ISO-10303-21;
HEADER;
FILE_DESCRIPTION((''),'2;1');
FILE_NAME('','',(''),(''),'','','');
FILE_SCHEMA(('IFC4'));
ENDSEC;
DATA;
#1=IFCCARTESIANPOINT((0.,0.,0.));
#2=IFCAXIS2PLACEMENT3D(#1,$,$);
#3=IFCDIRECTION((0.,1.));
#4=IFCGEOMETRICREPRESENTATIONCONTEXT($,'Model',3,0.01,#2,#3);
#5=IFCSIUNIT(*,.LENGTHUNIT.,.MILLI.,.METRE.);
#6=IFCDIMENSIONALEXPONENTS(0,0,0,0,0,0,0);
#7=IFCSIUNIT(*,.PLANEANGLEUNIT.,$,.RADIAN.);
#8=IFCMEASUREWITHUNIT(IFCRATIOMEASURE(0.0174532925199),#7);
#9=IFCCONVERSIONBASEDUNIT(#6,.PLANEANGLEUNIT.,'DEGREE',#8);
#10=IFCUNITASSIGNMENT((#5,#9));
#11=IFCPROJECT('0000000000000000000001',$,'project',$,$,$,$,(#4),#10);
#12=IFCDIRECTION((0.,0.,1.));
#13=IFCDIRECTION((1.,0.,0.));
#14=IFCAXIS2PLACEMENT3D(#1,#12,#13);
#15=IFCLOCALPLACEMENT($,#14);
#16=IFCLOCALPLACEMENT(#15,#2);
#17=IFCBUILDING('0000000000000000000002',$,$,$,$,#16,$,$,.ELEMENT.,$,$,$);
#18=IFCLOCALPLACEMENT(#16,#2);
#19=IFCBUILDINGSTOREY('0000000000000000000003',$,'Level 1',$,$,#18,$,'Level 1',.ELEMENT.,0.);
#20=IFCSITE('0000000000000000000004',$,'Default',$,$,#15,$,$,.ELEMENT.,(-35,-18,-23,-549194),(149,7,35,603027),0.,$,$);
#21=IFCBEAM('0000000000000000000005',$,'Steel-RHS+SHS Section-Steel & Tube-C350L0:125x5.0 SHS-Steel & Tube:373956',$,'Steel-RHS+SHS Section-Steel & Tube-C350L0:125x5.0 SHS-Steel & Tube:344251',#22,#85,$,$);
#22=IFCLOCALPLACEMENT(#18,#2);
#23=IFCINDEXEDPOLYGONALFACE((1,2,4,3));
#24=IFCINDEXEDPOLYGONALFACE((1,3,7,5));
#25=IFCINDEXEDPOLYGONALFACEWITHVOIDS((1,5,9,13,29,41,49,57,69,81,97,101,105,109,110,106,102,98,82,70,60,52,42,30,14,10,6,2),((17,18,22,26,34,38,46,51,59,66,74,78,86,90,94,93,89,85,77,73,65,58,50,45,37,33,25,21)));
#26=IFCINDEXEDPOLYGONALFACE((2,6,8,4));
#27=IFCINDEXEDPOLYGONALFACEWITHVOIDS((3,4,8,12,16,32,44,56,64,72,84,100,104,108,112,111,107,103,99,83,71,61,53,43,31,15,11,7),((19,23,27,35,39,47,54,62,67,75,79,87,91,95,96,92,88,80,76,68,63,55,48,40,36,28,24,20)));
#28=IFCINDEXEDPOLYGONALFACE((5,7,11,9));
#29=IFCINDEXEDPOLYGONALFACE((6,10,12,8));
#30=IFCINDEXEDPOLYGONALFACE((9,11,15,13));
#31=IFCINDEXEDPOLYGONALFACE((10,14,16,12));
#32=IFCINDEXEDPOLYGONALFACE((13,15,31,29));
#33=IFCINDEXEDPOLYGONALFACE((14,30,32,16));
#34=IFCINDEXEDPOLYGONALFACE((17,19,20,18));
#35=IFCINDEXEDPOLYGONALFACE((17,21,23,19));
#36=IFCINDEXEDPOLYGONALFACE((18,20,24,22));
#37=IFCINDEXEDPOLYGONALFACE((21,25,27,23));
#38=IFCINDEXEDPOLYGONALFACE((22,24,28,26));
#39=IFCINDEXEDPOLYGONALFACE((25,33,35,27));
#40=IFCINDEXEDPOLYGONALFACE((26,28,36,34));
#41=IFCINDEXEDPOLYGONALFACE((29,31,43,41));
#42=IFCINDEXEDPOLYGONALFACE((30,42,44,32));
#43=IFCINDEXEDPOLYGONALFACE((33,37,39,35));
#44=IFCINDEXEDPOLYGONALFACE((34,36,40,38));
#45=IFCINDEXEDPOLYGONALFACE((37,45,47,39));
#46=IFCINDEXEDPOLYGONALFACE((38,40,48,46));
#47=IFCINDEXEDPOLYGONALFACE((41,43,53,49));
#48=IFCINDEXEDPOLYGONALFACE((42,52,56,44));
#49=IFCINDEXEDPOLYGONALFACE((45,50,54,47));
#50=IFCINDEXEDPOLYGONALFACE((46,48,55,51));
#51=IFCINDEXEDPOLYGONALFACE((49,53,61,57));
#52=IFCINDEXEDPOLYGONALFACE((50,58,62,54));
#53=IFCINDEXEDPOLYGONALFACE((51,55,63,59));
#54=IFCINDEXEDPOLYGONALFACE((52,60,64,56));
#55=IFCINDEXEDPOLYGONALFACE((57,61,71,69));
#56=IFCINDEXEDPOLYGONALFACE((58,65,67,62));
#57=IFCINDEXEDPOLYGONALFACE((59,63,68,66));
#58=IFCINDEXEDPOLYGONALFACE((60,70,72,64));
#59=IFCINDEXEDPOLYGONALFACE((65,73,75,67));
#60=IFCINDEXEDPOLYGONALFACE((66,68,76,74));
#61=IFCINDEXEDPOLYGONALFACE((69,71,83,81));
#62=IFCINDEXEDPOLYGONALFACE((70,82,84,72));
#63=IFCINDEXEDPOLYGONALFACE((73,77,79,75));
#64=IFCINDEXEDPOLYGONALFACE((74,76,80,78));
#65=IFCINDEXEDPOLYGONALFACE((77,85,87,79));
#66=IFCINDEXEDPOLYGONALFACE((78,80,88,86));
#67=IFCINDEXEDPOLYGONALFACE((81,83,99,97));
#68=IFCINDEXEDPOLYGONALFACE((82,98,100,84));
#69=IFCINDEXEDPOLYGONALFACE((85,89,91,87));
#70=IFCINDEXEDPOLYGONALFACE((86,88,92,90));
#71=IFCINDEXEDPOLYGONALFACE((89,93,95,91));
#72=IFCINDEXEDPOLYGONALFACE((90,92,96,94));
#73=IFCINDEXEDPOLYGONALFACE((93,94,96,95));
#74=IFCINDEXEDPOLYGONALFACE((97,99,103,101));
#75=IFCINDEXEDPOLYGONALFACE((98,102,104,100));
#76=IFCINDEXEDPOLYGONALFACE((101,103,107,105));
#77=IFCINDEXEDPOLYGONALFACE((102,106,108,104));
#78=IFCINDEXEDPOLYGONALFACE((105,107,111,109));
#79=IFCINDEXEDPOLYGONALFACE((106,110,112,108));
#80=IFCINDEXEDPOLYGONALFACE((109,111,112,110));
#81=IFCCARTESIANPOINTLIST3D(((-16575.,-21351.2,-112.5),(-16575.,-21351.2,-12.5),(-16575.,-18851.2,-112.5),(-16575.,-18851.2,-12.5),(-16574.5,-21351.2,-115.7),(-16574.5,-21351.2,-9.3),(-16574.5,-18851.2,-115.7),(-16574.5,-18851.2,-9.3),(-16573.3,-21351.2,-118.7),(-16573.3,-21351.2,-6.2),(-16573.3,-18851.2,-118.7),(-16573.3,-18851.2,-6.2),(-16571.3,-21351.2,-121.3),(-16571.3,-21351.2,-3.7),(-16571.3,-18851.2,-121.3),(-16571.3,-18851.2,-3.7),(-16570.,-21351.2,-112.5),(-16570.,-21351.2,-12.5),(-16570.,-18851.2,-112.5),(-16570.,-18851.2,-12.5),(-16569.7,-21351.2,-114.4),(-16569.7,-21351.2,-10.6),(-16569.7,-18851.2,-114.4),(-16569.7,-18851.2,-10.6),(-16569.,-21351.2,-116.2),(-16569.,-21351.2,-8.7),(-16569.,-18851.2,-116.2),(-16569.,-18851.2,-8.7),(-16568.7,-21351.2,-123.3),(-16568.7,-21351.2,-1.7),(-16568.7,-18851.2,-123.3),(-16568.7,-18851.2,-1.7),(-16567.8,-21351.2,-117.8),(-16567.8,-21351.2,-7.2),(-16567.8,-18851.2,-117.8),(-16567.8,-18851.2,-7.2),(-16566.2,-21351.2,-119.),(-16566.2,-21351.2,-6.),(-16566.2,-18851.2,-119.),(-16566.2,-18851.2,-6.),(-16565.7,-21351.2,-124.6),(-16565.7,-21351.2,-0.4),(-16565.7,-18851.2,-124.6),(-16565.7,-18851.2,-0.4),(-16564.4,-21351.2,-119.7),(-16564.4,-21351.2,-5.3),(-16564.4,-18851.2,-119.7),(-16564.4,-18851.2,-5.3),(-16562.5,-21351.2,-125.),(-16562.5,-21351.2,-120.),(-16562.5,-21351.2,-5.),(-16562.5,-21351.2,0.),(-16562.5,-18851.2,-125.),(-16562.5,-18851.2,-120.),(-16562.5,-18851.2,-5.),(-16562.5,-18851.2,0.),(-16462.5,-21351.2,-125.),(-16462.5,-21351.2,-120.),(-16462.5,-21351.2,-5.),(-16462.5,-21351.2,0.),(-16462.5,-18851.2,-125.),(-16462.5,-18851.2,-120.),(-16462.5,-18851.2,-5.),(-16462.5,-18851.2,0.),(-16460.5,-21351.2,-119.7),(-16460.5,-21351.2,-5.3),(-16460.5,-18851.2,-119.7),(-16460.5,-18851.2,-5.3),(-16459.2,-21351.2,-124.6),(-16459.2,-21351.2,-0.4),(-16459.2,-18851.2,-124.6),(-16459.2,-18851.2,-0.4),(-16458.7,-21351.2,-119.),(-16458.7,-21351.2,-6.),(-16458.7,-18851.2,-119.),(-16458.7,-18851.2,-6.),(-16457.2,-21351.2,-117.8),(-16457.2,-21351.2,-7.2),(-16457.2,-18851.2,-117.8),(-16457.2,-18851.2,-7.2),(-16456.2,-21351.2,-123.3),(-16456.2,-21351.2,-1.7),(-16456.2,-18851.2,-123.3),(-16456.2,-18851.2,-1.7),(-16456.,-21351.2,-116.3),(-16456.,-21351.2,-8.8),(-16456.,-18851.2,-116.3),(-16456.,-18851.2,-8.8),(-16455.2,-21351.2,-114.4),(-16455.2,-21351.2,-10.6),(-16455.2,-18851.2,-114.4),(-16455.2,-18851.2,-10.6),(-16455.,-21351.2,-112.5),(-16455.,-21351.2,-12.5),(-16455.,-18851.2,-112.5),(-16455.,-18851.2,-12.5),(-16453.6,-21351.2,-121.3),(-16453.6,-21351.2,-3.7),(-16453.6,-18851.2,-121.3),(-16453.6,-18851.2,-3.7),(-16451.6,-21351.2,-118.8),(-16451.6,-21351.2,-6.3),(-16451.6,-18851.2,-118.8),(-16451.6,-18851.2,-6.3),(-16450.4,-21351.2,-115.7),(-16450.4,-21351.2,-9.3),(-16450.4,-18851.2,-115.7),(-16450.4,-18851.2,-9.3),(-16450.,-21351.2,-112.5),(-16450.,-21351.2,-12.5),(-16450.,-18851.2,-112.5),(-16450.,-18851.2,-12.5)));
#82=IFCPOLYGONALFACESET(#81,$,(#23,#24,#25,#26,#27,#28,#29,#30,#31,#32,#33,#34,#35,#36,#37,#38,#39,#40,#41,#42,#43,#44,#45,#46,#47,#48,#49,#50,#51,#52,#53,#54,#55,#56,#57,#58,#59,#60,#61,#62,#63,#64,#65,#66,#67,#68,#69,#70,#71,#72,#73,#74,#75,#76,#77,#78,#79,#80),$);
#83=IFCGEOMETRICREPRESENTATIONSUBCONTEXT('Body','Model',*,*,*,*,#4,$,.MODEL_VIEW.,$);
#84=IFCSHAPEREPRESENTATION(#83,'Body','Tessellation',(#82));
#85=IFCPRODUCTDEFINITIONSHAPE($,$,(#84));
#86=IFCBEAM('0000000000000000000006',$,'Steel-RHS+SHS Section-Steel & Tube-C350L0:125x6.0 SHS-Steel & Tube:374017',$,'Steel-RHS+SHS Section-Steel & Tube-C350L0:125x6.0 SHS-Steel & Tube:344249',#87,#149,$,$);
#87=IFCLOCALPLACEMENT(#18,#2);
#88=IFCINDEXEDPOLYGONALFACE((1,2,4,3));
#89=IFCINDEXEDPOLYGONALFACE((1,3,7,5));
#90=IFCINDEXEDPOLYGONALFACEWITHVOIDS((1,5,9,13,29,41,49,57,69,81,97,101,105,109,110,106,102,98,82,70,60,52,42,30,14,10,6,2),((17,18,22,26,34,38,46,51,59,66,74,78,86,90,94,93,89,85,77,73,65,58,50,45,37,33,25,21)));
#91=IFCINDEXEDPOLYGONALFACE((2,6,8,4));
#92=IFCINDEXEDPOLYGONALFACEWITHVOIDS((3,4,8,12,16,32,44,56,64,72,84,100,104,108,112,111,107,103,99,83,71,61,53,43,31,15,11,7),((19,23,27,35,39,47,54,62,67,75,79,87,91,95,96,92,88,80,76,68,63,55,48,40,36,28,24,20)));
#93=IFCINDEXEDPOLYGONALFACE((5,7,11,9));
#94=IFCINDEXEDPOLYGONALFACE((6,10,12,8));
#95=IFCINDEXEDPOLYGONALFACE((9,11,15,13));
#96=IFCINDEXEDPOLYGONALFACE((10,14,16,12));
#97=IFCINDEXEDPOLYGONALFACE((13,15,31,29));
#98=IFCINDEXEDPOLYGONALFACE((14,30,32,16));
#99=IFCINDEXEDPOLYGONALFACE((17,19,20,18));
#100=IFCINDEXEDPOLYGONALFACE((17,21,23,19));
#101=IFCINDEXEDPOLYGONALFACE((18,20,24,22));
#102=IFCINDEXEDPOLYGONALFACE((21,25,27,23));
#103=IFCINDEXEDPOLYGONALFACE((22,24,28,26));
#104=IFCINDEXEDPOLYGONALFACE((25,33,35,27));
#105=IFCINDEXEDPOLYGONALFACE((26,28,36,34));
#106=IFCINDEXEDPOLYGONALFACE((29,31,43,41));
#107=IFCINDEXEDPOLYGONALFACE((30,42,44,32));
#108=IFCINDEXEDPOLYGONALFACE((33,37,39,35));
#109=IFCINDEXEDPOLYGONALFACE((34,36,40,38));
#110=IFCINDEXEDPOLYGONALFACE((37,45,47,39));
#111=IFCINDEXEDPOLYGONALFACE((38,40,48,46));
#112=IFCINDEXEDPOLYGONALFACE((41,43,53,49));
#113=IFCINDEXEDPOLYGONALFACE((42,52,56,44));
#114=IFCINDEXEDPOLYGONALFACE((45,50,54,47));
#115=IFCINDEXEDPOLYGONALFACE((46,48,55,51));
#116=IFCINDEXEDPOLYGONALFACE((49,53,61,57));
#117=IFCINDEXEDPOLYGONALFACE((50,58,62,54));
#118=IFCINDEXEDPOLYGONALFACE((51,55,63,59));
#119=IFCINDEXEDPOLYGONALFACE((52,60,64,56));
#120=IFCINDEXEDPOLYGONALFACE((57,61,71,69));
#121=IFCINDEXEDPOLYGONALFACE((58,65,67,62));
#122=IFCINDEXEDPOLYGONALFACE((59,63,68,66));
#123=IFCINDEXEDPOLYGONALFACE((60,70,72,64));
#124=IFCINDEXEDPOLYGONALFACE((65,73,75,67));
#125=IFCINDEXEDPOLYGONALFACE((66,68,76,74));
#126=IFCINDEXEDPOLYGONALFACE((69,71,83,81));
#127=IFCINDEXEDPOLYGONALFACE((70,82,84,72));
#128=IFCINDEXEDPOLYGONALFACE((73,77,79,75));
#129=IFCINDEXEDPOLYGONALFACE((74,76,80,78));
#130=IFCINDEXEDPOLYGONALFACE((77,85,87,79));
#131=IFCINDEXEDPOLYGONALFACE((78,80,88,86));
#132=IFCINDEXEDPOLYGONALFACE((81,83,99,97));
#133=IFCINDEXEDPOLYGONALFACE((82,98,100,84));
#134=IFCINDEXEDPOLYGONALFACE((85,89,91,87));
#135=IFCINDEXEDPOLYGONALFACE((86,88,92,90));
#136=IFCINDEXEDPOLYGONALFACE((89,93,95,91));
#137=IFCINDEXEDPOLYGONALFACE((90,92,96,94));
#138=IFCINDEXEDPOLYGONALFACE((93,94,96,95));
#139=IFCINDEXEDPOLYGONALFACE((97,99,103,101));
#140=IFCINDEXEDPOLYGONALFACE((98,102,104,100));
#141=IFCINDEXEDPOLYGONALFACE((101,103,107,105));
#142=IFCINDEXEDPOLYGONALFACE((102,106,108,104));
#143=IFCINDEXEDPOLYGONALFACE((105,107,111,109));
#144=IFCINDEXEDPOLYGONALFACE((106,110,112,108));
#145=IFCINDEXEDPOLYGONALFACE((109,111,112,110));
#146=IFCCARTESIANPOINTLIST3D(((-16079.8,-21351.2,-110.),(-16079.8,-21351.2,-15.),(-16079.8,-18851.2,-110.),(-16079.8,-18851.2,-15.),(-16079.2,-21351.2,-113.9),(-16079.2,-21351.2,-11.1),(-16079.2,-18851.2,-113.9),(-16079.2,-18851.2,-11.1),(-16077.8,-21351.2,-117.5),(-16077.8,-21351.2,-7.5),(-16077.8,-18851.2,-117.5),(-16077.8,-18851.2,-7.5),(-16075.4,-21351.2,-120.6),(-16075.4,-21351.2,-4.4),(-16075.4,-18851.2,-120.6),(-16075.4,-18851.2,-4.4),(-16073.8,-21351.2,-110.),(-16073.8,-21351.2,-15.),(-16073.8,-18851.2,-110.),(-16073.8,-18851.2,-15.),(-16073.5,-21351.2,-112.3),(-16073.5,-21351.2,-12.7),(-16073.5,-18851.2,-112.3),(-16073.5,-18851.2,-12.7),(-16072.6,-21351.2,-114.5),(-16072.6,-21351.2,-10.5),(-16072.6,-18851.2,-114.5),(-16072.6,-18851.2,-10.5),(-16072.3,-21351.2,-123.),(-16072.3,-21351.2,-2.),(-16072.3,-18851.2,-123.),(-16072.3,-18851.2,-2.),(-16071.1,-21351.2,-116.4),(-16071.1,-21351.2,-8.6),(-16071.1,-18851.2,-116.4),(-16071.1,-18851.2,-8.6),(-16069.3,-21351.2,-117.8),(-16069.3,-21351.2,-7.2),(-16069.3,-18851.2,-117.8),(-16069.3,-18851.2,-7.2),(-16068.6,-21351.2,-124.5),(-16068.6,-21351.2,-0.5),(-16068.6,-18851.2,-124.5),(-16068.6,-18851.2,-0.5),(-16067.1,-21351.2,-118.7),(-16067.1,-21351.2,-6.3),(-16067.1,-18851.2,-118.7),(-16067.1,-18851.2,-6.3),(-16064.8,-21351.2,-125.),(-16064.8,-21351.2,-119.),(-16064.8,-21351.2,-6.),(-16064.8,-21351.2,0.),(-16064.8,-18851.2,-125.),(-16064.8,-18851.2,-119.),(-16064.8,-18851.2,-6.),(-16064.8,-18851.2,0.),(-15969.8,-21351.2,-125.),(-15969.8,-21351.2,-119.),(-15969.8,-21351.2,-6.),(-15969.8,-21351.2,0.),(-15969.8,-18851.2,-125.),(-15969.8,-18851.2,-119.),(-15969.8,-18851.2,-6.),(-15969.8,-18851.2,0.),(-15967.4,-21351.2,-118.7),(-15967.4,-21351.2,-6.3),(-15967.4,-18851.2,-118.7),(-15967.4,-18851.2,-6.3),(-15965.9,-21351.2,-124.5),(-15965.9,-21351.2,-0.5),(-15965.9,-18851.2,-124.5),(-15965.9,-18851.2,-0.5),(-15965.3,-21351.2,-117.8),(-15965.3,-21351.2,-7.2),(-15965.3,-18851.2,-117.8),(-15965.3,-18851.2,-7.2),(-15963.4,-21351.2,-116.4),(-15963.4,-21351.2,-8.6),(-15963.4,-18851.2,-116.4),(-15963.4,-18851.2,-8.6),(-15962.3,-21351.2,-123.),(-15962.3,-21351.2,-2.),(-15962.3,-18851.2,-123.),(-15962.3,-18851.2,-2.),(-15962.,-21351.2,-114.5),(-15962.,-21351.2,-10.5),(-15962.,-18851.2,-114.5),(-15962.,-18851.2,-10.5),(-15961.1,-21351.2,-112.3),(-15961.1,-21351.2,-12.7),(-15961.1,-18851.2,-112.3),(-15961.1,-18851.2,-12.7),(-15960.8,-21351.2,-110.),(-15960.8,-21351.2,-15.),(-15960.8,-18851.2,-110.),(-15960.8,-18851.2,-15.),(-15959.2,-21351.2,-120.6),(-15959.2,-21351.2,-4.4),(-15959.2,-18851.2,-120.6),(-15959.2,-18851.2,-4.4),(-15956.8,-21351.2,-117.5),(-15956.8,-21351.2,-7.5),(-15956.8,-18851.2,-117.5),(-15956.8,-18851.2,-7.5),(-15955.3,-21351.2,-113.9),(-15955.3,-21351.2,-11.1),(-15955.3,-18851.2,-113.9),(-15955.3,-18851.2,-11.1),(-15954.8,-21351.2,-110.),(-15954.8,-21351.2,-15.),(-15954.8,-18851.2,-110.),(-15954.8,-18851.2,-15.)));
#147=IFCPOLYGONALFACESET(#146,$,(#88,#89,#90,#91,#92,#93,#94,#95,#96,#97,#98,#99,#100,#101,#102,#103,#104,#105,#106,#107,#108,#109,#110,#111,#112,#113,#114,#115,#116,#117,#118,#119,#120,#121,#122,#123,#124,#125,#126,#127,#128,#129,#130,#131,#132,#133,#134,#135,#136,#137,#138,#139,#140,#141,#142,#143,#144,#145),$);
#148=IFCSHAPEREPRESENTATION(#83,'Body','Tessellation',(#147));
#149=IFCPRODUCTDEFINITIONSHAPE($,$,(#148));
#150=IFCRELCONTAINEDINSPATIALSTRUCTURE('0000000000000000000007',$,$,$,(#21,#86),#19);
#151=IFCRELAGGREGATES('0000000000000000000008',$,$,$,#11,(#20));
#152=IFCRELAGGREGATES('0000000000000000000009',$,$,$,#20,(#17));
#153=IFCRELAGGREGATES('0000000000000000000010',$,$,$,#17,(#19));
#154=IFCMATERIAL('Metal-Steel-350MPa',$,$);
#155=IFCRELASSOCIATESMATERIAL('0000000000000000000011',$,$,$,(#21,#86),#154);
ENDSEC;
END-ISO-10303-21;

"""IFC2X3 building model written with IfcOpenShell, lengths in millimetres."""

from ifc_helpers import new_model, entity, si_unit, converted_unit, direction, frame, frame_2d, origin, origin_with_axes, place, context, subcontext, project, spatial, polyline, circle_curve, parameter, trimmed, segment, composite_curve, outline, extrude, material, element, save


model = new_model("IFC2X3")

# Units and contexts
model_context = context("Model", 3, precision=0.01, world=origin(), true_north=direction((0.0, 1.0)))
body_context = subcontext(model_context, "Body", "Model", "MODEL_VIEW")
ifc_project = project(units=[si_unit("LENGTHUNIT", "METRE", prefix="MILLI"), converted_unit("PLANEANGLEUNIT", "DEGREE", entity("IfcRatioMeasure", 0.0174532925199), si_unit("PLANEANGLEUNIT", "RADIAN"), dimensions=[0, 0, 0, 0, 0, 0, 0])], contexts=[model_context])

# Site, building, storey
site_placement = place(None, origin_with_axes())
site = spatial("IfcSite", under=ifc_project, at=site_placement, Name="Default", CompositionType="ELEMENT", RefLatitude=(-35, -18, -23, -549194), RefLongitude=(149, 7, 35, 603027), RefElevation=0.0)
building_placement = place(site_placement, origin())
building = spatial("IfcBuilding", under=site, at=building_placement, CompositionType="ELEMENT")
storey_placement = place(building_placement, origin())
storey = spatial("IfcBuildingStorey", under=building, at=storey_placement, Name="Level 1", LongName="Level 1", CompositionType="ELEMENT", Elevation=0.0)

# Beams
ifc_material = material(Name="Metal-Steel-350MPa")
beam_1_placement = place(storey_placement, frame((-16512.5, -18851.2, 0.0), z_axis=(0.0, 0.0, 1.0), x_axis=(0.0, -1.0, 0.0)))
element("IfcBeam", 1, at=beam_1_placement, inside=storey, material=ifc_material, Name="Steel-RHS+SHS Section-Steel & Tube-C350L0:125x5.0 SHS-Steel & Tube:373956", ObjectType="Steel-RHS+SHS Section-Steel & Tube-C350L0:125x5.0 SHS-Steel & Tube:344251", context=body_context, shape_type="SweptSolid", body=[
    extrude(outline(composite_curve([segment(trimmed(circle_curve(frame_2d((-50.0, -50.0), x_axis=(1.0, 0.0)), 12.5), [parameter(180.0)], [parameter(270.0)], True, "PARAMETER"), True, "CONTINUOUS"), segment(polyline([(-50.0, -62.5), (50.0, -62.5)]), True, "CONTINUOUS"), segment(trimmed(circle_curve(frame_2d((50.0, -50.0), x_axis=(1.0, 0.0)), 12.5), [parameter(270.0)], [parameter(0.0)], True, "PARAMETER"), True, "CONTINUOUS"), segment(polyline([(62.5, -50.0), (62.5, 50.0)]), True, "CONTINUOUS"), segment(trimmed(circle_curve(frame_2d((50.0, 50.0), x_axis=(1.0, 0.0)), 12.5), [parameter(0.0)], [parameter(90.0)], True, "PARAMETER"), True, "CONTINUOUS"), segment(polyline([(50.0, 62.5), (-50.0, 62.5)]), True, "CONTINUOUS"), segment(trimmed(circle_curve(frame_2d((-50.0, 50.0), x_axis=(1.0, 0.0)), 12.5), [parameter(90.0)], [parameter(180.0)], True, "PARAMETER"), True, "CONTINUOUS"), segment(polyline([(-62.5, 50.0), (-62.5, -50.0)]), True, "CONTINUOUS")], self_intersect=False), holes=[composite_curve([segment(polyline([(50.0, -57.5), (-50.0, -57.5)]), True, "CONTINUOUS"), segment(trimmed(circle_curve(frame_2d((-50.0, -50.0), x_axis=(1.0, 0.0)), 7.5), [parameter(180.0)], [parameter(270.0)], True, "PARAMETER"), False, "CONTINUOUS"), segment(polyline([(-57.5, -50.0), (-57.5, 50.0)]), True, "CONTINUOUS"), segment(trimmed(circle_curve(frame_2d((-50.0, 50.0), x_axis=(1.0, 0.0)), 7.5), [parameter(90.0)], [parameter(180.0)], True, "PARAMETER"), False, "CONTINUOUS"), segment(polyline([(-50.0, 57.5), (50.0, 57.5)]), True, "CONTINUOUS"), segment(trimmed(circle_curve(frame_2d((50.0, 50.0), x_axis=(1.0, 0.0)), 7.5), [parameter(360.0)], [parameter(90.0)], True, "PARAMETER"), False, "CONTINUOUS"), segment(polyline([(57.5, 50.0), (57.5, -50.0)]), True, "CONTINUOUS"), segment(trimmed(circle_curve(frame_2d((50.0, -50.0), x_axis=(1.0, 0.0)), 7.5), [parameter(270.0)], [parameter(0.0)], True, "PARAMETER"), False, "CONTINUOUS")], self_intersect=False)]), frame((0.0, 0.0, -62.5), z_axis=(1.0, 0.0, 0.0), x_axis=(0.0, -1.0, 0.0)), (0.0, 0.0, 1.0), 2500.0),
])
beam_2_placement = place(storey_placement, frame((-16017.3, -18851.2, 0.0), z_axis=(0.0, 0.0, 1.0), x_axis=(0.0, -1.0, 0.0)))
element("IfcBeam", 2, at=beam_2_placement, inside=storey, material=ifc_material, Name="Steel-RHS+SHS Section-Steel & Tube-C350L0:125x6.0 SHS-Steel & Tube:374017", ObjectType="Steel-RHS+SHS Section-Steel & Tube-C350L0:125x6.0 SHS-Steel & Tube:344249", context=body_context, shape_type="SweptSolid", body=[
    extrude(outline(composite_curve([segment(trimmed(circle_curve(frame_2d((-47.5, -47.5), x_axis=(1.0, 0.0)), 15.0), [parameter(180.0)], [parameter(270.0)], True, "PARAMETER"), True, "CONTINUOUS"), segment(polyline([(-47.5, -62.5), (47.5, -62.5)]), True, "CONTINUOUS"), segment(trimmed(circle_curve(frame_2d((47.5, -47.5), x_axis=(1.0, 0.0)), 15.0), [parameter(270.0)], [parameter(0.0)], True, "PARAMETER"), True, "CONTINUOUS"), segment(polyline([(62.5, -47.5), (62.5, 47.5)]), True, "CONTINUOUS"), segment(trimmed(circle_curve(frame_2d((47.5, 47.5), x_axis=(1.0, 0.0)), 15.0), [parameter(0.0)], [parameter(90.0)], True, "PARAMETER"), True, "CONTINUOUS"), segment(polyline([(47.5, 62.5), (-47.5, 62.5)]), True, "CONTINUOUS"), segment(trimmed(circle_curve(frame_2d((-47.5, 47.5), x_axis=(1.0, 0.0)), 15.0), [parameter(90.0)], [parameter(180.0)], True, "PARAMETER"), True, "CONTINUOUS"), segment(polyline([(-62.5, 47.5), (-62.5, -47.5)]), True, "CONTINUOUS")], self_intersect=False), holes=[composite_curve([segment(polyline([(47.5, -56.5), (-47.5, -56.5)]), True, "CONTINUOUS"), segment(trimmed(circle_curve(frame_2d((-47.5, -47.5), x_axis=(1.0, 0.0)), 9.0), [parameter(180.0)], [parameter(270.0)], True, "PARAMETER"), False, "CONTINUOUS"), segment(polyline([(-56.5, -47.5), (-56.5, 47.5)]), True, "CONTINUOUS"), segment(trimmed(circle_curve(frame_2d((-47.5, 47.5), x_axis=(1.0, 0.0)), 9.0), [parameter(90.0)], [parameter(180.0)], True, "PARAMETER"), False, "CONTINUOUS"), segment(polyline([(-47.5, 56.5), (47.5, 56.5)]), True, "CONTINUOUS"), segment(trimmed(circle_curve(frame_2d((47.5, 47.5), x_axis=(1.0, 0.0)), 9.0), [parameter(360.0)], [parameter(90.0)], True, "PARAMETER"), False, "CONTINUOUS"), segment(polyline([(56.5, 47.5), (56.5, -47.5)]), True, "CONTINUOUS"), segment(trimmed(circle_curve(frame_2d((47.5, -47.5), x_axis=(1.0, 0.0)), 9.0), [parameter(270.0)], [parameter(0.0)], True, "PARAMETER"), False, "CONTINUOUS")], self_intersect=False)]), frame((0.0, 0.0, -62.5), z_axis=(1.0, 0.0, 0.0), x_axis=(0.0, -1.0, 0.0)), (0.0, 0.0, 1.0), 2500.0),
])

save(model, "model.ifc")
